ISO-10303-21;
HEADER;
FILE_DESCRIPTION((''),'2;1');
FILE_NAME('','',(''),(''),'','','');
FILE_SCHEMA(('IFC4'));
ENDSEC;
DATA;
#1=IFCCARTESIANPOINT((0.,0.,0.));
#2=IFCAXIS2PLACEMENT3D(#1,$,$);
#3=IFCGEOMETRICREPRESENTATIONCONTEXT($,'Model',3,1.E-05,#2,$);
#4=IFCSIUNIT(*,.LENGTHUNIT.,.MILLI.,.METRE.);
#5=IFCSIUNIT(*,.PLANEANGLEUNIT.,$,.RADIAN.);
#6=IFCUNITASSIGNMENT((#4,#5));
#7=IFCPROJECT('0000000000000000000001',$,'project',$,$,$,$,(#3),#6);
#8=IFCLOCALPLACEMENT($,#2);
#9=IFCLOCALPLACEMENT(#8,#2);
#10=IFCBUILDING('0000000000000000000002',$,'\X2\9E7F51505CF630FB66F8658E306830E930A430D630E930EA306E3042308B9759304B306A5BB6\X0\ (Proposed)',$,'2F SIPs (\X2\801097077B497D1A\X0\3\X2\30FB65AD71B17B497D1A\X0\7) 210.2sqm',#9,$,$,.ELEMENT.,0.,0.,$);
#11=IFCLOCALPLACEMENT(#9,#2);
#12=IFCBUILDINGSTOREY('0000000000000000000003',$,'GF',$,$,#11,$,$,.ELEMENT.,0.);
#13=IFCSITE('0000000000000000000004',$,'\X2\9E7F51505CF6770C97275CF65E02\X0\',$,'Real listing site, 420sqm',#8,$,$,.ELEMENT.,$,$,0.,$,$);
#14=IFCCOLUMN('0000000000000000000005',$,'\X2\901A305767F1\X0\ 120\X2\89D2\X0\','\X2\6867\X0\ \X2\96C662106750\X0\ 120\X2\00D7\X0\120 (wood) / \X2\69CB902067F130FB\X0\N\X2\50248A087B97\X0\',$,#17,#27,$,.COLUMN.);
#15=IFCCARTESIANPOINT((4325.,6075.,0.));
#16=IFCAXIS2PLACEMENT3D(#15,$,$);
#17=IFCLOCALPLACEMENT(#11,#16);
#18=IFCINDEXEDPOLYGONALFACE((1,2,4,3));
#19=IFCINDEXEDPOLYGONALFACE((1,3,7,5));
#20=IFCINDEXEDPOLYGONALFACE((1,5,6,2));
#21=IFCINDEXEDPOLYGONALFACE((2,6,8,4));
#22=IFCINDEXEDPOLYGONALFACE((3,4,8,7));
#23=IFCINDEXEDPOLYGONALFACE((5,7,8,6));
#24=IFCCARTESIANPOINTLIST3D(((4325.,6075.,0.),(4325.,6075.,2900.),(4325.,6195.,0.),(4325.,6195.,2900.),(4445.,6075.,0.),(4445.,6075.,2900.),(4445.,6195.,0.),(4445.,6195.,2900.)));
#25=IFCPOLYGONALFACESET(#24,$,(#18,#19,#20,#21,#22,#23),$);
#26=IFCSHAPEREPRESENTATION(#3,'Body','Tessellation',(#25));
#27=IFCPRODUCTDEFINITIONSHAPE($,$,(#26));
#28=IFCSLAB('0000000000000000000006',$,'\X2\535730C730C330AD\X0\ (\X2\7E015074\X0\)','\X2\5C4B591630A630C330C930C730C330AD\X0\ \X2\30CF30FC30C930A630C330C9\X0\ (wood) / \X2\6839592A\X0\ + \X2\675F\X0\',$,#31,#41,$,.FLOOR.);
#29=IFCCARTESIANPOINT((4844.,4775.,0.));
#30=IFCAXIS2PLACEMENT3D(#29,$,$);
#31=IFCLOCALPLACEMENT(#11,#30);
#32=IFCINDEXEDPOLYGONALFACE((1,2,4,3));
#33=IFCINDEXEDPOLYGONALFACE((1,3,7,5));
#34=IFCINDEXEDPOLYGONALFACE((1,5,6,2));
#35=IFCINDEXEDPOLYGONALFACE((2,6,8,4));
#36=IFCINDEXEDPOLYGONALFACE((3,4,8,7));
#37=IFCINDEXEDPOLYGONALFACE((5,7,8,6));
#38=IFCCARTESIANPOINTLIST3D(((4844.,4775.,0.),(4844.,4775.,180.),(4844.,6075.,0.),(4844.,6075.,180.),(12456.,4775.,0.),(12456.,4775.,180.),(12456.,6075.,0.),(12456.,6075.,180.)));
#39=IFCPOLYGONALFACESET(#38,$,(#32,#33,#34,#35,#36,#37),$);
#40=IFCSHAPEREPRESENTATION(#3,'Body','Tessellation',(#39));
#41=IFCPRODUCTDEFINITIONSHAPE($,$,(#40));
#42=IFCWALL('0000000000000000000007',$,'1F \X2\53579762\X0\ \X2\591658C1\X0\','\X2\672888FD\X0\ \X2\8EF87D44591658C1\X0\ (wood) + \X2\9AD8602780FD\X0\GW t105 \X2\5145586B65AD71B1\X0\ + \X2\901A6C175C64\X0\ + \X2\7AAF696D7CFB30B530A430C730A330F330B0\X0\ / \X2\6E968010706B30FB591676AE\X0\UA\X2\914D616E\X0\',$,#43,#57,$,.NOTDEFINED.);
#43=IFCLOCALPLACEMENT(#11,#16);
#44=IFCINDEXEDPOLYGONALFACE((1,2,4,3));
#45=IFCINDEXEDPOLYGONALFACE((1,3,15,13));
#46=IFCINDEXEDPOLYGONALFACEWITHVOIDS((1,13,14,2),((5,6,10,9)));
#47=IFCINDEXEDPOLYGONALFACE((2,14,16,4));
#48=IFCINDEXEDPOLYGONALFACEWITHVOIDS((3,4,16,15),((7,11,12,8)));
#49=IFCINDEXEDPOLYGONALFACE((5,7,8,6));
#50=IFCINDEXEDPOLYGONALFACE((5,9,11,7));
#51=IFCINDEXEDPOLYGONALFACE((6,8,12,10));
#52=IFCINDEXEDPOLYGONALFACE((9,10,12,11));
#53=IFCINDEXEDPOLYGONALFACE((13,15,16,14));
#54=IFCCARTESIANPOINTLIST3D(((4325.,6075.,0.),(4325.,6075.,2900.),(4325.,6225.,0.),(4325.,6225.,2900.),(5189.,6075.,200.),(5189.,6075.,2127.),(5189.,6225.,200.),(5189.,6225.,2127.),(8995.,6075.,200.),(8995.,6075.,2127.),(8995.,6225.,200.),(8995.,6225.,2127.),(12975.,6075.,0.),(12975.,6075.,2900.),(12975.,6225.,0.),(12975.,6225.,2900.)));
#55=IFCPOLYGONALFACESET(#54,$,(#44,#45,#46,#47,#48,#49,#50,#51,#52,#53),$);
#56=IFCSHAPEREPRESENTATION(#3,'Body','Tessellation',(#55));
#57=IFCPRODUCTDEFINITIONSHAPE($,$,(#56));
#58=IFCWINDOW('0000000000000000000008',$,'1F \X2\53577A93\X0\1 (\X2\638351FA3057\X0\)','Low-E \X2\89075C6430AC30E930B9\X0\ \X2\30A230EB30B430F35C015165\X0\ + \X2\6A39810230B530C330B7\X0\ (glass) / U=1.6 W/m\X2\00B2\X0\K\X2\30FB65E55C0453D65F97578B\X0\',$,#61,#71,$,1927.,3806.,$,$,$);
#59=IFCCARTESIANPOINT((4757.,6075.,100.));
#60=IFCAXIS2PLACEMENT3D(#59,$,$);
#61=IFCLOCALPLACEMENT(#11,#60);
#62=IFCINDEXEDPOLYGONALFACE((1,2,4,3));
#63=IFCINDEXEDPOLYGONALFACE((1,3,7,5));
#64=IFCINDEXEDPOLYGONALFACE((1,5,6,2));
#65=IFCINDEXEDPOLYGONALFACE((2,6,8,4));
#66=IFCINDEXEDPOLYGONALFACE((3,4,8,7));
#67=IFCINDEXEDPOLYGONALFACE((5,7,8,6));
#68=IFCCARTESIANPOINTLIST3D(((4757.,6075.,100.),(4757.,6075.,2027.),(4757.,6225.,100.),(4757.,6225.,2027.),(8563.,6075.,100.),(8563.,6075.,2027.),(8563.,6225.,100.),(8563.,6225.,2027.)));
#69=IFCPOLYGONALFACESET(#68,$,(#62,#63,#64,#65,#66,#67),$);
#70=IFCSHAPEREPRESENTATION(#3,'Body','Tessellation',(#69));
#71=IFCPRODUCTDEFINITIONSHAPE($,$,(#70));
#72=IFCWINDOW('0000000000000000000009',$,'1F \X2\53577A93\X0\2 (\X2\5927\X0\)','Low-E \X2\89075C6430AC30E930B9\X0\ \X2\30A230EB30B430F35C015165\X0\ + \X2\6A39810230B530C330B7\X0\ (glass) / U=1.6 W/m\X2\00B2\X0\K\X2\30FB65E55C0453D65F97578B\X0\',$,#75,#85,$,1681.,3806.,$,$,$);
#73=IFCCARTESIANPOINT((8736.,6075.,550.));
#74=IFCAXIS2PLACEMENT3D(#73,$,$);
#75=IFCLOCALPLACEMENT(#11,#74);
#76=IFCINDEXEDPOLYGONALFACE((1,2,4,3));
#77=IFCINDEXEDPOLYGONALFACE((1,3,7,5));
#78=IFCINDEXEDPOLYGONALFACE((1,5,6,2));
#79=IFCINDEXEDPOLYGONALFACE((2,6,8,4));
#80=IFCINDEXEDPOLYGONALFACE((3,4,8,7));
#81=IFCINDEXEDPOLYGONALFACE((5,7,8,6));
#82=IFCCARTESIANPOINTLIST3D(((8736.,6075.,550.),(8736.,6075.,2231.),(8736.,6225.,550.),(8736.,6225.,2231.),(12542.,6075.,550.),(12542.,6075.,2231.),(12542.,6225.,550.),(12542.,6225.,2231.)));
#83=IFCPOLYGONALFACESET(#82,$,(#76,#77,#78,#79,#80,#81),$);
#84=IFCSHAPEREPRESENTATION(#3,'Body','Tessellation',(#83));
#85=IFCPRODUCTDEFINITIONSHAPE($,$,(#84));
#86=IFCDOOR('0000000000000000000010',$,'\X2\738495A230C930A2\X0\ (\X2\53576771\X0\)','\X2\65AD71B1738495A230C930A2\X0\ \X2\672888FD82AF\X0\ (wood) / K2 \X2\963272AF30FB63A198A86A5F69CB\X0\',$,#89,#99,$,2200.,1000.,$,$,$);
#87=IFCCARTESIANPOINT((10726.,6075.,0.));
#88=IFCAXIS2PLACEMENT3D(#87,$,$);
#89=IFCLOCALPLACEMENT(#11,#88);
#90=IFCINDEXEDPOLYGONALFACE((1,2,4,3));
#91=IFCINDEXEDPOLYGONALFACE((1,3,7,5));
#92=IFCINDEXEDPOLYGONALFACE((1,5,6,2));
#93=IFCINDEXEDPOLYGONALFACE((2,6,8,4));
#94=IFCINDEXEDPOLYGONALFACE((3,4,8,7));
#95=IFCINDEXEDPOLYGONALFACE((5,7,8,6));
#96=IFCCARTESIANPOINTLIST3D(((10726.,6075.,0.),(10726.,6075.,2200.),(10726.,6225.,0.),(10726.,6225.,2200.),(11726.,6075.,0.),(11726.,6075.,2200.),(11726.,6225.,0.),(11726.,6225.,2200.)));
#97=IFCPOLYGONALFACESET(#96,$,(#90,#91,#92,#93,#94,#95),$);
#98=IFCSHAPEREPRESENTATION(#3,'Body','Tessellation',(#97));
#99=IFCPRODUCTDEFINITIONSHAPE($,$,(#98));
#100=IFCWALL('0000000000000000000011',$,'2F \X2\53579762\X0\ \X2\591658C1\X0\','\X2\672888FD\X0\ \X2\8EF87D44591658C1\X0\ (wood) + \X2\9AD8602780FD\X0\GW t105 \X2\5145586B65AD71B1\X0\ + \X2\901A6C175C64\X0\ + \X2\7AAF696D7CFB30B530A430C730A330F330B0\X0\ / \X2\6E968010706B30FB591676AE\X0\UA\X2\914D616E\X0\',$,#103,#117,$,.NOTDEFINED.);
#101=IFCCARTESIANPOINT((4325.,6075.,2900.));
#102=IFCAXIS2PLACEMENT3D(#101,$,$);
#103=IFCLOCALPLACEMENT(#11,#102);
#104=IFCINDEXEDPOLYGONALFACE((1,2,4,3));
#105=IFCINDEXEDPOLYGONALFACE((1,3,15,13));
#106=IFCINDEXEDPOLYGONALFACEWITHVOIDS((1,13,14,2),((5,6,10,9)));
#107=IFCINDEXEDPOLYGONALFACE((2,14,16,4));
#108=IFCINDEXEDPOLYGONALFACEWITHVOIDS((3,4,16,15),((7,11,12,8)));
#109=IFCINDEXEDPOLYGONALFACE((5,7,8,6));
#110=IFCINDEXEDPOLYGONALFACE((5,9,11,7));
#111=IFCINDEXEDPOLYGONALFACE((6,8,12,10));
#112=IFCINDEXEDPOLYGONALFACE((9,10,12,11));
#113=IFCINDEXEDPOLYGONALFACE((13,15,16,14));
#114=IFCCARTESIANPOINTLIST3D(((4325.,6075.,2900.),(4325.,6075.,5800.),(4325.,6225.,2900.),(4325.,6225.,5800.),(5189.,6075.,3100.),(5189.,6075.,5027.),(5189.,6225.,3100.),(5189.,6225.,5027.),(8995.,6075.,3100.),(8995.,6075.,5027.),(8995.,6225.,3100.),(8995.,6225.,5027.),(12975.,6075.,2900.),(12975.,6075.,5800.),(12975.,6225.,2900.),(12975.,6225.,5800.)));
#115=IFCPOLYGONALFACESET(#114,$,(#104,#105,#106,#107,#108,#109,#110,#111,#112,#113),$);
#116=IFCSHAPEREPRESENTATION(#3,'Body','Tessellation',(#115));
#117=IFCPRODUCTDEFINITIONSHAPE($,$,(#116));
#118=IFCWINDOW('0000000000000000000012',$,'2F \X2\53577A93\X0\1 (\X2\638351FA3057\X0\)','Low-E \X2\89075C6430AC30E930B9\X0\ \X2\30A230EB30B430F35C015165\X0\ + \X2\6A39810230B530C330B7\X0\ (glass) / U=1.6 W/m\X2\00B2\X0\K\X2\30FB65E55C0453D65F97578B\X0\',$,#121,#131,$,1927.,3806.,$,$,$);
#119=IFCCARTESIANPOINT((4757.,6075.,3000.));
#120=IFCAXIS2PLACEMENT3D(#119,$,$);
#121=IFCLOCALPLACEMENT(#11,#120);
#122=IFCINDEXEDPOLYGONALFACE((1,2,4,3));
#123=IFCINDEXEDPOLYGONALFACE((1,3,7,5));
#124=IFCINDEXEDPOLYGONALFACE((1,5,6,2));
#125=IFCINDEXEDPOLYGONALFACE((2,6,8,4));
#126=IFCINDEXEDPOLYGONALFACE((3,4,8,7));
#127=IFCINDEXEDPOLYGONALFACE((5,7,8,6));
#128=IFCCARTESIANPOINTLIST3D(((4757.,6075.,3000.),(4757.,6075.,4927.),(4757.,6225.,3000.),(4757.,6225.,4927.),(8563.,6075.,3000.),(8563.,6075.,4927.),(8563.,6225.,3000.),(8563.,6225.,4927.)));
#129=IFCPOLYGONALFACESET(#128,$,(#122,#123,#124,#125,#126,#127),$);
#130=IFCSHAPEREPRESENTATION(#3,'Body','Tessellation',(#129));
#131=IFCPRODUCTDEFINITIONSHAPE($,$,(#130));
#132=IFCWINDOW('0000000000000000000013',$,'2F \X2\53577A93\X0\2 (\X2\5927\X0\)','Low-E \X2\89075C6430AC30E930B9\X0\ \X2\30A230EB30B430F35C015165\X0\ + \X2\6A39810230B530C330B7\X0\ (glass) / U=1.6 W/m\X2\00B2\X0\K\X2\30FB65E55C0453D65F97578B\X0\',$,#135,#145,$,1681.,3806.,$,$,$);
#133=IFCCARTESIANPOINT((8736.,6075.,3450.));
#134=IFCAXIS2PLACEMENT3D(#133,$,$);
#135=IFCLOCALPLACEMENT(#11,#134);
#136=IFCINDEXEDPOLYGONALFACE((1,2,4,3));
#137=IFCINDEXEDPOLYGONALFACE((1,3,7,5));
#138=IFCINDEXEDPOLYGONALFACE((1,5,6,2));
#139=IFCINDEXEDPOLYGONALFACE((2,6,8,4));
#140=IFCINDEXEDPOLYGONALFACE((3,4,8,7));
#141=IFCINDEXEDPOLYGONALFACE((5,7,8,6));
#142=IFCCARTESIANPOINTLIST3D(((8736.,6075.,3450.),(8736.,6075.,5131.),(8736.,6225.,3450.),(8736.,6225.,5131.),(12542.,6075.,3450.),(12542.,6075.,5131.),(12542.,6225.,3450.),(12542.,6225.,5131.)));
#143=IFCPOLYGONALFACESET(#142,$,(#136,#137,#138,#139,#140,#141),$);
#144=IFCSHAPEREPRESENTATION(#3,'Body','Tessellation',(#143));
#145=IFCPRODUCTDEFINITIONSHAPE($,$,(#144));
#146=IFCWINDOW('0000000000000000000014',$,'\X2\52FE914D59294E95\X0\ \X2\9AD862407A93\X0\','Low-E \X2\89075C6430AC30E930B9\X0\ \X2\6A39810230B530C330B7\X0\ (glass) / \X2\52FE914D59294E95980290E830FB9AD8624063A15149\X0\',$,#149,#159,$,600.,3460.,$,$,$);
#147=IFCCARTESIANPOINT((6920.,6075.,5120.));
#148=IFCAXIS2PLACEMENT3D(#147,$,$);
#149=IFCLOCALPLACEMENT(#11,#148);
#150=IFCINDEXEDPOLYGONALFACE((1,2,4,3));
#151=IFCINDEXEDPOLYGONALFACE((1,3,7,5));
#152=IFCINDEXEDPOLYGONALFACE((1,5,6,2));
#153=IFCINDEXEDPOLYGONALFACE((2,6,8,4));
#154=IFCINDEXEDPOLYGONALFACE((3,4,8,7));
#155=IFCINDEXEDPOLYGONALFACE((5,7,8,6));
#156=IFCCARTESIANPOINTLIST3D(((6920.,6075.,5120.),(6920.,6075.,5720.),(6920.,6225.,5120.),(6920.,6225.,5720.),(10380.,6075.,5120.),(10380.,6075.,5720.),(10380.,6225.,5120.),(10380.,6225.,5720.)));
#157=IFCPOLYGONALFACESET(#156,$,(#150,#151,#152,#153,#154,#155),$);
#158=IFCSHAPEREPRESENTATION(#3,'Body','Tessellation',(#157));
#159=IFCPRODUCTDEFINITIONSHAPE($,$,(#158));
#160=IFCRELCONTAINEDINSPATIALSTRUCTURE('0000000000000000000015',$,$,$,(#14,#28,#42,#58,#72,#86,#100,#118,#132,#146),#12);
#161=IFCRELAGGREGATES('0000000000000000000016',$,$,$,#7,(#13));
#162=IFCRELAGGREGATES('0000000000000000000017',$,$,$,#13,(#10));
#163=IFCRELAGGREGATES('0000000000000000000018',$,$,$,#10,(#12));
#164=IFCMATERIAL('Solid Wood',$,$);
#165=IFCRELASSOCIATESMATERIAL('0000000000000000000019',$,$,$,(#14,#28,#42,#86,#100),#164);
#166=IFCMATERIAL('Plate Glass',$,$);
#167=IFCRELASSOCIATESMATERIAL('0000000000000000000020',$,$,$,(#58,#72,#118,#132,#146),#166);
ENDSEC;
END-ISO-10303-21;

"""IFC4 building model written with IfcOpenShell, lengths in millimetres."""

from ifc_helpers import new_model, si_unit, frame, frame_2d, origin, place, context, project, spatial, rectangle, extrude, material, element, fill, save


model = new_model("IFC4")

# Units and contexts
model_context = context("Model", 3, precision=1e-05, world=origin())
ifc_project = project(units=[si_unit("LENGTHUNIT", "METRE", prefix="MILLI"), si_unit("PLANEANGLEUNIT", "RADIAN")], contexts=[model_context])

# Site, building, storey
site_placement = place(None, origin())
site = spatial("IfcSite", under=ifc_project, at=site_placement, Name="鹿児島県霧島市", ObjectType="Real listing site, 420sqm", CompositionType="ELEMENT", RefElevation=0.0)
building_placement = place(site_placement, origin())
building = spatial("IfcBuilding", under=site, at=building_placement, Name="鹿児島・書斎とライブラリのある静かな家 (Proposed)", ObjectType="2F SIPs (耐震等級3・断熱等級7) 210.2sqm", CompositionType="ELEMENT", ElevationOfRefHeight=0.0, ElevationOfTerrain=0.0)
storey_placement = place(building_placement, origin())
storey = spatial("IfcBuildingStorey", under=building, at=storey_placement, Name="GF", CompositionType="ELEMENT", Elevation=0.0)

# Column
ifc_material_1 = material(Name="Solid Wood")
column_placement = place(storey_placement, frame((4325.0, 6075.0, 0.0)))
element("IfcColumn", 1, at=column_placement, inside=storey, material=ifc_material_1, Name="通し柱 120角", Description="桧 集成材 120×120 (wood) / 構造柱・N値計算", PredefinedType="COLUMN", context=model_context, shape_type="SweptSolid", body=[
    extrude(rectangle(XDim=120.0, YDim=120.0, at=frame_2d((60.0, 60.0))), frame((4325.0, 6075.0, 0.0)), (0.0, 0.0, 1.0), 2900.0),
])

# Slab
slab_1_placement = place(storey_placement, frame((4844.0, 4775.0, 0.0)))
element("IfcSlab", 2, at=slab_1_placement, inside=storey, material=ifc_material_1, Name="南デッキ (縁側)", Description="屋外ウッドデッキ ハードウッド (wood) / 根太 + 束", PredefinedType="FLOOR", context=model_context, shape_type="SweptSolid", body=[
    extrude(rectangle(XDim=7612.0, YDim=1300.0, at=frame_2d((3806.0, 650.0))), frame((4844.0, 4775.0, 0.0)), (0.0, 0.0, 1.0), 180.0),
])

# Wall, openings, windows, door
wall_1_placement = place(storey_placement, frame((4325.0, 6075.0, 0.0)))
wall_1 = element("IfcWall", 3, at=wall_1_placement, inside=storey, material=ifc_material_1, Name="1F 南面 外壁", Description="木製 軸組外壁 (wood) + 高性能GW t105 充填断熱 + 通気層 + 窯業系サイディング / 準耐火・外皮UA配慮", PredefinedType="NOTDEFINED", context=model_context, shape_type="SweptSolid", body=[
    extrude(rectangle(XDim=8650.0, YDim=150.0, at=frame_2d((4325.0, 75.0))), frame((4325.0, 6075.0, 0.0)), (0.0, 0.0, 1.0), 2900.0),
])
opening_1_placement = place(storey_placement, frame((4757.0, 6075.0, 100.0)))
opening_1 = element("IfcOpeningElement", 4, at=opening_1_placement, cuts=wall_1, PredefinedType="NOTDEFINED", context=model_context, shape_type="SweptSolid", body=[
    extrude(rectangle(XDim=3806.0, YDim=150.0, at=frame_2d((1903.0, 75.0))), frame((4757.0, 6075.0, 100.0)), (0.0, 0.0, 1.0), 1927.0),
])
opening_2_placement = place(storey_placement, frame((8736.0, 6075.0, 550.0)))
opening_2 = element("IfcOpeningElement", 5, at=opening_2_placement, cuts=wall_1, PredefinedType="NOTDEFINED", context=model_context, shape_type="SweptSolid", body=[
    extrude(rectangle(XDim=3806.0, YDim=150.0, at=frame_2d((1903.0, 75.0))), frame((8736.0, 6075.0, 550.0)), (0.0, 0.0, 1.0), 1681.0),
])
opening_3_placement = place(storey_placement, frame((10726.0, 6075.0, 0.0)))
opening_3 = element("IfcOpeningElement", 6, at=opening_3_placement, cuts=wall_1, PredefinedType="NOTDEFINED", context=model_context, shape_type="SweptSolid", body=[
    extrude(rectangle(XDim=1000.0, YDim=150.0, at=frame_2d((500.0, 75.0))), frame((10726.0, 6075.0, 0.0)), (0.0, 0.0, 1.0), 2200.0),
])
ifc_material_2 = material(Name="Plate Glass")
window_1_placement = place(storey_placement, frame((4757.0, 6075.0, 100.0)))
window_1 = element("IfcWindow", 7, at=window_1_placement, inside=storey, material=ifc_material_2, Name="1F 南窓1 (掃出し)", Description="Low-E 複層ガラス アルゴン封入 + 樹脂サッシ (glass) / U=1.6 W/m²K・日射取得型", OverallHeight=1927.0, OverallWidth=3806.0, context=model_context, shape_type="SweptSolid", body=[
    extrude(rectangle(XDim=3806.0, YDim=150.0, at=frame_2d((1903.0, 75.0))), frame((4757.0, 6075.0, 100.0)), (0.0, 0.0, 1.0), 1927.0),
])
fill(opening_1, window_1)
window_2_placement = place(storey_placement, frame((8736.0, 6075.0, 550.0)))
window_2 = element("IfcWindow", 8, at=window_2_placement, inside=storey, material=ifc_material_2, Name="1F 南窓2 (大)", Description="Low-E 複層ガラス アルゴン封入 + 樹脂サッシ (glass) / U=1.6 W/m²K・日射取得型", OverallHeight=1681.0, OverallWidth=3806.0, context=model_context, shape_type="SweptSolid", body=[
    extrude(rectangle(XDim=3806.0, YDim=150.0, at=frame_2d((1903.0, 75.0))), frame((8736.0, 6075.0, 550.0)), (0.0, 0.0, 1.0), 1681.0),
])
fill(opening_2, window_2)
door_placement = place(storey_placement, frame((10726.0, 6075.0, 0.0)))
door = element("IfcDoor", 9, at=door_placement, inside=storey, material=ifc_material_1, Name="玄関ドア (南東)", Description="断熱玄関ドア 木製芯 (wood) / K2 防犯・採風機構", OverallHeight=2200.0, OverallWidth=1000.0, context=model_context, shape_type="SweptSolid", body=[
    extrude(rectangle(XDim=1000.0, YDim=150.0, at=frame_2d((500.0, 75.0))), frame((10726.0, 6075.0, 0.0)), (0.0, 0.0, 1.0), 2200.0),
])
fill(opening_3, door)

# Wall, openings, windows
wall_2_placement = place(storey_placement, frame((4325.0, 6075.0, 2900.0)))
wall_2 = element("IfcWall", 10, at=wall_2_placement, inside=storey, material=ifc_material_1, Name="2F 南面 外壁", Description="木製 軸組外壁 (wood) + 高性能GW t105 充填断熱 + 通気層 + 窯業系サイディング / 準耐火・外皮UA配慮", PredefinedType="NOTDEFINED", context=model_context, shape_type="SweptSolid", body=[
    extrude(rectangle(XDim=8650.0, YDim=150.0, at=frame_2d((4325.0, 75.0))), frame((4325.0, 6075.0, 2900.0)), (0.0, 0.0, 1.0), 2900.0),
])
opening_4_placement = place(storey_placement, frame((4757.0, 6075.0, 3000.0)))
opening_4 = element("IfcOpeningElement", 11, at=opening_4_placement, cuts=wall_2, PredefinedType="NOTDEFINED", context=model_context, shape_type="SweptSolid", body=[
    extrude(rectangle(XDim=3806.0, YDim=150.0, at=frame_2d((1903.0, 75.0))), frame((4757.0, 6075.0, 3000.0)), (0.0, 0.0, 1.0), 1927.0),
])
opening_5_placement = place(storey_placement, frame((8736.0, 6075.0, 3450.0)))
opening_5 = element("IfcOpeningElement", 12, at=opening_5_placement, cuts=wall_2, PredefinedType="NOTDEFINED", context=model_context, shape_type="SweptSolid", body=[
    extrude(rectangle(XDim=3806.0, YDim=150.0, at=frame_2d((1903.0, 75.0))), frame((8736.0, 6075.0, 3450.0)), (0.0, 0.0, 1.0), 1681.0),
])
opening_6_placement = place(storey_placement, frame((6920.0, 6075.0, 5120.0)))
opening_6 = element("IfcOpeningElement", 13, at=opening_6_placement, cuts=wall_2, PredefinedType="NOTDEFINED", context=model_context, shape_type="SweptSolid", body=[
    extrude(rectangle(XDim=3460.0, YDim=150.0, at=frame_2d((1730.0, 75.0))), frame((6920.0, 6075.0, 5120.0)), (0.0, 0.0, 1.0), 600.0),
])
window_3_placement = place(storey_placement, frame((4757.0, 6075.0, 3000.0)))
window_3 = element("IfcWindow", 14, at=window_3_placement, inside=storey, material=ifc_material_2, Name="2F 南窓1 (掃出し)", Description="Low-E 複層ガラス アルゴン封入 + 樹脂サッシ (glass) / U=1.6 W/m²K・日射取得型", OverallHeight=1927.0, OverallWidth=3806.0, context=model_context, shape_type="SweptSolid", body=[
    extrude(rectangle(XDim=3806.0, YDim=150.0, at=frame_2d((1903.0, 75.0))), frame((4757.0, 6075.0, 3000.0)), (0.0, 0.0, 1.0), 1927.0),
])
fill(opening_4, window_3)
window_4_placement = place(storey_placement, frame((8736.0, 6075.0, 3450.0)))
window_4 = element("IfcWindow", 15, at=window_4_placement, inside=storey, material=ifc_material_2, Name="2F 南窓2 (大)", Description="Low-E 複層ガラス アルゴン封入 + 樹脂サッシ (glass) / U=1.6 W/m²K・日射取得型", OverallHeight=1681.0, OverallWidth=3806.0, context=model_context, shape_type="SweptSolid", body=[
    extrude(rectangle(XDim=3806.0, YDim=150.0, at=frame_2d((1903.0, 75.0))), frame((8736.0, 6075.0, 3450.0)), (0.0, 0.0, 1.0), 1681.0),
])
fill(opening_5, window_4)
window_5_placement = place(storey_placement, frame((6920.0, 6075.0, 5120.0)))
window_5 = element("IfcWindow", 16, at=window_5_placement, inside=storey, material=ifc_material_2, Name="勾配天井 高所窓", Description="Low-E 複層ガラス 樹脂サッシ (glass) / 勾配天井頂部・高所採光", OverallHeight=600.0, OverallWidth=3460.0, context=model_context, shape_type="SweptSolid", body=[
    extrude(rectangle(XDim=3460.0, YDim=150.0, at=frame_2d((1730.0, 75.0))), frame((6920.0, 6075.0, 5120.0)), (0.0, 0.0, 1.0), 600.0),
])
fill(opening_6, window_5)

save(model, "model.ifc")
